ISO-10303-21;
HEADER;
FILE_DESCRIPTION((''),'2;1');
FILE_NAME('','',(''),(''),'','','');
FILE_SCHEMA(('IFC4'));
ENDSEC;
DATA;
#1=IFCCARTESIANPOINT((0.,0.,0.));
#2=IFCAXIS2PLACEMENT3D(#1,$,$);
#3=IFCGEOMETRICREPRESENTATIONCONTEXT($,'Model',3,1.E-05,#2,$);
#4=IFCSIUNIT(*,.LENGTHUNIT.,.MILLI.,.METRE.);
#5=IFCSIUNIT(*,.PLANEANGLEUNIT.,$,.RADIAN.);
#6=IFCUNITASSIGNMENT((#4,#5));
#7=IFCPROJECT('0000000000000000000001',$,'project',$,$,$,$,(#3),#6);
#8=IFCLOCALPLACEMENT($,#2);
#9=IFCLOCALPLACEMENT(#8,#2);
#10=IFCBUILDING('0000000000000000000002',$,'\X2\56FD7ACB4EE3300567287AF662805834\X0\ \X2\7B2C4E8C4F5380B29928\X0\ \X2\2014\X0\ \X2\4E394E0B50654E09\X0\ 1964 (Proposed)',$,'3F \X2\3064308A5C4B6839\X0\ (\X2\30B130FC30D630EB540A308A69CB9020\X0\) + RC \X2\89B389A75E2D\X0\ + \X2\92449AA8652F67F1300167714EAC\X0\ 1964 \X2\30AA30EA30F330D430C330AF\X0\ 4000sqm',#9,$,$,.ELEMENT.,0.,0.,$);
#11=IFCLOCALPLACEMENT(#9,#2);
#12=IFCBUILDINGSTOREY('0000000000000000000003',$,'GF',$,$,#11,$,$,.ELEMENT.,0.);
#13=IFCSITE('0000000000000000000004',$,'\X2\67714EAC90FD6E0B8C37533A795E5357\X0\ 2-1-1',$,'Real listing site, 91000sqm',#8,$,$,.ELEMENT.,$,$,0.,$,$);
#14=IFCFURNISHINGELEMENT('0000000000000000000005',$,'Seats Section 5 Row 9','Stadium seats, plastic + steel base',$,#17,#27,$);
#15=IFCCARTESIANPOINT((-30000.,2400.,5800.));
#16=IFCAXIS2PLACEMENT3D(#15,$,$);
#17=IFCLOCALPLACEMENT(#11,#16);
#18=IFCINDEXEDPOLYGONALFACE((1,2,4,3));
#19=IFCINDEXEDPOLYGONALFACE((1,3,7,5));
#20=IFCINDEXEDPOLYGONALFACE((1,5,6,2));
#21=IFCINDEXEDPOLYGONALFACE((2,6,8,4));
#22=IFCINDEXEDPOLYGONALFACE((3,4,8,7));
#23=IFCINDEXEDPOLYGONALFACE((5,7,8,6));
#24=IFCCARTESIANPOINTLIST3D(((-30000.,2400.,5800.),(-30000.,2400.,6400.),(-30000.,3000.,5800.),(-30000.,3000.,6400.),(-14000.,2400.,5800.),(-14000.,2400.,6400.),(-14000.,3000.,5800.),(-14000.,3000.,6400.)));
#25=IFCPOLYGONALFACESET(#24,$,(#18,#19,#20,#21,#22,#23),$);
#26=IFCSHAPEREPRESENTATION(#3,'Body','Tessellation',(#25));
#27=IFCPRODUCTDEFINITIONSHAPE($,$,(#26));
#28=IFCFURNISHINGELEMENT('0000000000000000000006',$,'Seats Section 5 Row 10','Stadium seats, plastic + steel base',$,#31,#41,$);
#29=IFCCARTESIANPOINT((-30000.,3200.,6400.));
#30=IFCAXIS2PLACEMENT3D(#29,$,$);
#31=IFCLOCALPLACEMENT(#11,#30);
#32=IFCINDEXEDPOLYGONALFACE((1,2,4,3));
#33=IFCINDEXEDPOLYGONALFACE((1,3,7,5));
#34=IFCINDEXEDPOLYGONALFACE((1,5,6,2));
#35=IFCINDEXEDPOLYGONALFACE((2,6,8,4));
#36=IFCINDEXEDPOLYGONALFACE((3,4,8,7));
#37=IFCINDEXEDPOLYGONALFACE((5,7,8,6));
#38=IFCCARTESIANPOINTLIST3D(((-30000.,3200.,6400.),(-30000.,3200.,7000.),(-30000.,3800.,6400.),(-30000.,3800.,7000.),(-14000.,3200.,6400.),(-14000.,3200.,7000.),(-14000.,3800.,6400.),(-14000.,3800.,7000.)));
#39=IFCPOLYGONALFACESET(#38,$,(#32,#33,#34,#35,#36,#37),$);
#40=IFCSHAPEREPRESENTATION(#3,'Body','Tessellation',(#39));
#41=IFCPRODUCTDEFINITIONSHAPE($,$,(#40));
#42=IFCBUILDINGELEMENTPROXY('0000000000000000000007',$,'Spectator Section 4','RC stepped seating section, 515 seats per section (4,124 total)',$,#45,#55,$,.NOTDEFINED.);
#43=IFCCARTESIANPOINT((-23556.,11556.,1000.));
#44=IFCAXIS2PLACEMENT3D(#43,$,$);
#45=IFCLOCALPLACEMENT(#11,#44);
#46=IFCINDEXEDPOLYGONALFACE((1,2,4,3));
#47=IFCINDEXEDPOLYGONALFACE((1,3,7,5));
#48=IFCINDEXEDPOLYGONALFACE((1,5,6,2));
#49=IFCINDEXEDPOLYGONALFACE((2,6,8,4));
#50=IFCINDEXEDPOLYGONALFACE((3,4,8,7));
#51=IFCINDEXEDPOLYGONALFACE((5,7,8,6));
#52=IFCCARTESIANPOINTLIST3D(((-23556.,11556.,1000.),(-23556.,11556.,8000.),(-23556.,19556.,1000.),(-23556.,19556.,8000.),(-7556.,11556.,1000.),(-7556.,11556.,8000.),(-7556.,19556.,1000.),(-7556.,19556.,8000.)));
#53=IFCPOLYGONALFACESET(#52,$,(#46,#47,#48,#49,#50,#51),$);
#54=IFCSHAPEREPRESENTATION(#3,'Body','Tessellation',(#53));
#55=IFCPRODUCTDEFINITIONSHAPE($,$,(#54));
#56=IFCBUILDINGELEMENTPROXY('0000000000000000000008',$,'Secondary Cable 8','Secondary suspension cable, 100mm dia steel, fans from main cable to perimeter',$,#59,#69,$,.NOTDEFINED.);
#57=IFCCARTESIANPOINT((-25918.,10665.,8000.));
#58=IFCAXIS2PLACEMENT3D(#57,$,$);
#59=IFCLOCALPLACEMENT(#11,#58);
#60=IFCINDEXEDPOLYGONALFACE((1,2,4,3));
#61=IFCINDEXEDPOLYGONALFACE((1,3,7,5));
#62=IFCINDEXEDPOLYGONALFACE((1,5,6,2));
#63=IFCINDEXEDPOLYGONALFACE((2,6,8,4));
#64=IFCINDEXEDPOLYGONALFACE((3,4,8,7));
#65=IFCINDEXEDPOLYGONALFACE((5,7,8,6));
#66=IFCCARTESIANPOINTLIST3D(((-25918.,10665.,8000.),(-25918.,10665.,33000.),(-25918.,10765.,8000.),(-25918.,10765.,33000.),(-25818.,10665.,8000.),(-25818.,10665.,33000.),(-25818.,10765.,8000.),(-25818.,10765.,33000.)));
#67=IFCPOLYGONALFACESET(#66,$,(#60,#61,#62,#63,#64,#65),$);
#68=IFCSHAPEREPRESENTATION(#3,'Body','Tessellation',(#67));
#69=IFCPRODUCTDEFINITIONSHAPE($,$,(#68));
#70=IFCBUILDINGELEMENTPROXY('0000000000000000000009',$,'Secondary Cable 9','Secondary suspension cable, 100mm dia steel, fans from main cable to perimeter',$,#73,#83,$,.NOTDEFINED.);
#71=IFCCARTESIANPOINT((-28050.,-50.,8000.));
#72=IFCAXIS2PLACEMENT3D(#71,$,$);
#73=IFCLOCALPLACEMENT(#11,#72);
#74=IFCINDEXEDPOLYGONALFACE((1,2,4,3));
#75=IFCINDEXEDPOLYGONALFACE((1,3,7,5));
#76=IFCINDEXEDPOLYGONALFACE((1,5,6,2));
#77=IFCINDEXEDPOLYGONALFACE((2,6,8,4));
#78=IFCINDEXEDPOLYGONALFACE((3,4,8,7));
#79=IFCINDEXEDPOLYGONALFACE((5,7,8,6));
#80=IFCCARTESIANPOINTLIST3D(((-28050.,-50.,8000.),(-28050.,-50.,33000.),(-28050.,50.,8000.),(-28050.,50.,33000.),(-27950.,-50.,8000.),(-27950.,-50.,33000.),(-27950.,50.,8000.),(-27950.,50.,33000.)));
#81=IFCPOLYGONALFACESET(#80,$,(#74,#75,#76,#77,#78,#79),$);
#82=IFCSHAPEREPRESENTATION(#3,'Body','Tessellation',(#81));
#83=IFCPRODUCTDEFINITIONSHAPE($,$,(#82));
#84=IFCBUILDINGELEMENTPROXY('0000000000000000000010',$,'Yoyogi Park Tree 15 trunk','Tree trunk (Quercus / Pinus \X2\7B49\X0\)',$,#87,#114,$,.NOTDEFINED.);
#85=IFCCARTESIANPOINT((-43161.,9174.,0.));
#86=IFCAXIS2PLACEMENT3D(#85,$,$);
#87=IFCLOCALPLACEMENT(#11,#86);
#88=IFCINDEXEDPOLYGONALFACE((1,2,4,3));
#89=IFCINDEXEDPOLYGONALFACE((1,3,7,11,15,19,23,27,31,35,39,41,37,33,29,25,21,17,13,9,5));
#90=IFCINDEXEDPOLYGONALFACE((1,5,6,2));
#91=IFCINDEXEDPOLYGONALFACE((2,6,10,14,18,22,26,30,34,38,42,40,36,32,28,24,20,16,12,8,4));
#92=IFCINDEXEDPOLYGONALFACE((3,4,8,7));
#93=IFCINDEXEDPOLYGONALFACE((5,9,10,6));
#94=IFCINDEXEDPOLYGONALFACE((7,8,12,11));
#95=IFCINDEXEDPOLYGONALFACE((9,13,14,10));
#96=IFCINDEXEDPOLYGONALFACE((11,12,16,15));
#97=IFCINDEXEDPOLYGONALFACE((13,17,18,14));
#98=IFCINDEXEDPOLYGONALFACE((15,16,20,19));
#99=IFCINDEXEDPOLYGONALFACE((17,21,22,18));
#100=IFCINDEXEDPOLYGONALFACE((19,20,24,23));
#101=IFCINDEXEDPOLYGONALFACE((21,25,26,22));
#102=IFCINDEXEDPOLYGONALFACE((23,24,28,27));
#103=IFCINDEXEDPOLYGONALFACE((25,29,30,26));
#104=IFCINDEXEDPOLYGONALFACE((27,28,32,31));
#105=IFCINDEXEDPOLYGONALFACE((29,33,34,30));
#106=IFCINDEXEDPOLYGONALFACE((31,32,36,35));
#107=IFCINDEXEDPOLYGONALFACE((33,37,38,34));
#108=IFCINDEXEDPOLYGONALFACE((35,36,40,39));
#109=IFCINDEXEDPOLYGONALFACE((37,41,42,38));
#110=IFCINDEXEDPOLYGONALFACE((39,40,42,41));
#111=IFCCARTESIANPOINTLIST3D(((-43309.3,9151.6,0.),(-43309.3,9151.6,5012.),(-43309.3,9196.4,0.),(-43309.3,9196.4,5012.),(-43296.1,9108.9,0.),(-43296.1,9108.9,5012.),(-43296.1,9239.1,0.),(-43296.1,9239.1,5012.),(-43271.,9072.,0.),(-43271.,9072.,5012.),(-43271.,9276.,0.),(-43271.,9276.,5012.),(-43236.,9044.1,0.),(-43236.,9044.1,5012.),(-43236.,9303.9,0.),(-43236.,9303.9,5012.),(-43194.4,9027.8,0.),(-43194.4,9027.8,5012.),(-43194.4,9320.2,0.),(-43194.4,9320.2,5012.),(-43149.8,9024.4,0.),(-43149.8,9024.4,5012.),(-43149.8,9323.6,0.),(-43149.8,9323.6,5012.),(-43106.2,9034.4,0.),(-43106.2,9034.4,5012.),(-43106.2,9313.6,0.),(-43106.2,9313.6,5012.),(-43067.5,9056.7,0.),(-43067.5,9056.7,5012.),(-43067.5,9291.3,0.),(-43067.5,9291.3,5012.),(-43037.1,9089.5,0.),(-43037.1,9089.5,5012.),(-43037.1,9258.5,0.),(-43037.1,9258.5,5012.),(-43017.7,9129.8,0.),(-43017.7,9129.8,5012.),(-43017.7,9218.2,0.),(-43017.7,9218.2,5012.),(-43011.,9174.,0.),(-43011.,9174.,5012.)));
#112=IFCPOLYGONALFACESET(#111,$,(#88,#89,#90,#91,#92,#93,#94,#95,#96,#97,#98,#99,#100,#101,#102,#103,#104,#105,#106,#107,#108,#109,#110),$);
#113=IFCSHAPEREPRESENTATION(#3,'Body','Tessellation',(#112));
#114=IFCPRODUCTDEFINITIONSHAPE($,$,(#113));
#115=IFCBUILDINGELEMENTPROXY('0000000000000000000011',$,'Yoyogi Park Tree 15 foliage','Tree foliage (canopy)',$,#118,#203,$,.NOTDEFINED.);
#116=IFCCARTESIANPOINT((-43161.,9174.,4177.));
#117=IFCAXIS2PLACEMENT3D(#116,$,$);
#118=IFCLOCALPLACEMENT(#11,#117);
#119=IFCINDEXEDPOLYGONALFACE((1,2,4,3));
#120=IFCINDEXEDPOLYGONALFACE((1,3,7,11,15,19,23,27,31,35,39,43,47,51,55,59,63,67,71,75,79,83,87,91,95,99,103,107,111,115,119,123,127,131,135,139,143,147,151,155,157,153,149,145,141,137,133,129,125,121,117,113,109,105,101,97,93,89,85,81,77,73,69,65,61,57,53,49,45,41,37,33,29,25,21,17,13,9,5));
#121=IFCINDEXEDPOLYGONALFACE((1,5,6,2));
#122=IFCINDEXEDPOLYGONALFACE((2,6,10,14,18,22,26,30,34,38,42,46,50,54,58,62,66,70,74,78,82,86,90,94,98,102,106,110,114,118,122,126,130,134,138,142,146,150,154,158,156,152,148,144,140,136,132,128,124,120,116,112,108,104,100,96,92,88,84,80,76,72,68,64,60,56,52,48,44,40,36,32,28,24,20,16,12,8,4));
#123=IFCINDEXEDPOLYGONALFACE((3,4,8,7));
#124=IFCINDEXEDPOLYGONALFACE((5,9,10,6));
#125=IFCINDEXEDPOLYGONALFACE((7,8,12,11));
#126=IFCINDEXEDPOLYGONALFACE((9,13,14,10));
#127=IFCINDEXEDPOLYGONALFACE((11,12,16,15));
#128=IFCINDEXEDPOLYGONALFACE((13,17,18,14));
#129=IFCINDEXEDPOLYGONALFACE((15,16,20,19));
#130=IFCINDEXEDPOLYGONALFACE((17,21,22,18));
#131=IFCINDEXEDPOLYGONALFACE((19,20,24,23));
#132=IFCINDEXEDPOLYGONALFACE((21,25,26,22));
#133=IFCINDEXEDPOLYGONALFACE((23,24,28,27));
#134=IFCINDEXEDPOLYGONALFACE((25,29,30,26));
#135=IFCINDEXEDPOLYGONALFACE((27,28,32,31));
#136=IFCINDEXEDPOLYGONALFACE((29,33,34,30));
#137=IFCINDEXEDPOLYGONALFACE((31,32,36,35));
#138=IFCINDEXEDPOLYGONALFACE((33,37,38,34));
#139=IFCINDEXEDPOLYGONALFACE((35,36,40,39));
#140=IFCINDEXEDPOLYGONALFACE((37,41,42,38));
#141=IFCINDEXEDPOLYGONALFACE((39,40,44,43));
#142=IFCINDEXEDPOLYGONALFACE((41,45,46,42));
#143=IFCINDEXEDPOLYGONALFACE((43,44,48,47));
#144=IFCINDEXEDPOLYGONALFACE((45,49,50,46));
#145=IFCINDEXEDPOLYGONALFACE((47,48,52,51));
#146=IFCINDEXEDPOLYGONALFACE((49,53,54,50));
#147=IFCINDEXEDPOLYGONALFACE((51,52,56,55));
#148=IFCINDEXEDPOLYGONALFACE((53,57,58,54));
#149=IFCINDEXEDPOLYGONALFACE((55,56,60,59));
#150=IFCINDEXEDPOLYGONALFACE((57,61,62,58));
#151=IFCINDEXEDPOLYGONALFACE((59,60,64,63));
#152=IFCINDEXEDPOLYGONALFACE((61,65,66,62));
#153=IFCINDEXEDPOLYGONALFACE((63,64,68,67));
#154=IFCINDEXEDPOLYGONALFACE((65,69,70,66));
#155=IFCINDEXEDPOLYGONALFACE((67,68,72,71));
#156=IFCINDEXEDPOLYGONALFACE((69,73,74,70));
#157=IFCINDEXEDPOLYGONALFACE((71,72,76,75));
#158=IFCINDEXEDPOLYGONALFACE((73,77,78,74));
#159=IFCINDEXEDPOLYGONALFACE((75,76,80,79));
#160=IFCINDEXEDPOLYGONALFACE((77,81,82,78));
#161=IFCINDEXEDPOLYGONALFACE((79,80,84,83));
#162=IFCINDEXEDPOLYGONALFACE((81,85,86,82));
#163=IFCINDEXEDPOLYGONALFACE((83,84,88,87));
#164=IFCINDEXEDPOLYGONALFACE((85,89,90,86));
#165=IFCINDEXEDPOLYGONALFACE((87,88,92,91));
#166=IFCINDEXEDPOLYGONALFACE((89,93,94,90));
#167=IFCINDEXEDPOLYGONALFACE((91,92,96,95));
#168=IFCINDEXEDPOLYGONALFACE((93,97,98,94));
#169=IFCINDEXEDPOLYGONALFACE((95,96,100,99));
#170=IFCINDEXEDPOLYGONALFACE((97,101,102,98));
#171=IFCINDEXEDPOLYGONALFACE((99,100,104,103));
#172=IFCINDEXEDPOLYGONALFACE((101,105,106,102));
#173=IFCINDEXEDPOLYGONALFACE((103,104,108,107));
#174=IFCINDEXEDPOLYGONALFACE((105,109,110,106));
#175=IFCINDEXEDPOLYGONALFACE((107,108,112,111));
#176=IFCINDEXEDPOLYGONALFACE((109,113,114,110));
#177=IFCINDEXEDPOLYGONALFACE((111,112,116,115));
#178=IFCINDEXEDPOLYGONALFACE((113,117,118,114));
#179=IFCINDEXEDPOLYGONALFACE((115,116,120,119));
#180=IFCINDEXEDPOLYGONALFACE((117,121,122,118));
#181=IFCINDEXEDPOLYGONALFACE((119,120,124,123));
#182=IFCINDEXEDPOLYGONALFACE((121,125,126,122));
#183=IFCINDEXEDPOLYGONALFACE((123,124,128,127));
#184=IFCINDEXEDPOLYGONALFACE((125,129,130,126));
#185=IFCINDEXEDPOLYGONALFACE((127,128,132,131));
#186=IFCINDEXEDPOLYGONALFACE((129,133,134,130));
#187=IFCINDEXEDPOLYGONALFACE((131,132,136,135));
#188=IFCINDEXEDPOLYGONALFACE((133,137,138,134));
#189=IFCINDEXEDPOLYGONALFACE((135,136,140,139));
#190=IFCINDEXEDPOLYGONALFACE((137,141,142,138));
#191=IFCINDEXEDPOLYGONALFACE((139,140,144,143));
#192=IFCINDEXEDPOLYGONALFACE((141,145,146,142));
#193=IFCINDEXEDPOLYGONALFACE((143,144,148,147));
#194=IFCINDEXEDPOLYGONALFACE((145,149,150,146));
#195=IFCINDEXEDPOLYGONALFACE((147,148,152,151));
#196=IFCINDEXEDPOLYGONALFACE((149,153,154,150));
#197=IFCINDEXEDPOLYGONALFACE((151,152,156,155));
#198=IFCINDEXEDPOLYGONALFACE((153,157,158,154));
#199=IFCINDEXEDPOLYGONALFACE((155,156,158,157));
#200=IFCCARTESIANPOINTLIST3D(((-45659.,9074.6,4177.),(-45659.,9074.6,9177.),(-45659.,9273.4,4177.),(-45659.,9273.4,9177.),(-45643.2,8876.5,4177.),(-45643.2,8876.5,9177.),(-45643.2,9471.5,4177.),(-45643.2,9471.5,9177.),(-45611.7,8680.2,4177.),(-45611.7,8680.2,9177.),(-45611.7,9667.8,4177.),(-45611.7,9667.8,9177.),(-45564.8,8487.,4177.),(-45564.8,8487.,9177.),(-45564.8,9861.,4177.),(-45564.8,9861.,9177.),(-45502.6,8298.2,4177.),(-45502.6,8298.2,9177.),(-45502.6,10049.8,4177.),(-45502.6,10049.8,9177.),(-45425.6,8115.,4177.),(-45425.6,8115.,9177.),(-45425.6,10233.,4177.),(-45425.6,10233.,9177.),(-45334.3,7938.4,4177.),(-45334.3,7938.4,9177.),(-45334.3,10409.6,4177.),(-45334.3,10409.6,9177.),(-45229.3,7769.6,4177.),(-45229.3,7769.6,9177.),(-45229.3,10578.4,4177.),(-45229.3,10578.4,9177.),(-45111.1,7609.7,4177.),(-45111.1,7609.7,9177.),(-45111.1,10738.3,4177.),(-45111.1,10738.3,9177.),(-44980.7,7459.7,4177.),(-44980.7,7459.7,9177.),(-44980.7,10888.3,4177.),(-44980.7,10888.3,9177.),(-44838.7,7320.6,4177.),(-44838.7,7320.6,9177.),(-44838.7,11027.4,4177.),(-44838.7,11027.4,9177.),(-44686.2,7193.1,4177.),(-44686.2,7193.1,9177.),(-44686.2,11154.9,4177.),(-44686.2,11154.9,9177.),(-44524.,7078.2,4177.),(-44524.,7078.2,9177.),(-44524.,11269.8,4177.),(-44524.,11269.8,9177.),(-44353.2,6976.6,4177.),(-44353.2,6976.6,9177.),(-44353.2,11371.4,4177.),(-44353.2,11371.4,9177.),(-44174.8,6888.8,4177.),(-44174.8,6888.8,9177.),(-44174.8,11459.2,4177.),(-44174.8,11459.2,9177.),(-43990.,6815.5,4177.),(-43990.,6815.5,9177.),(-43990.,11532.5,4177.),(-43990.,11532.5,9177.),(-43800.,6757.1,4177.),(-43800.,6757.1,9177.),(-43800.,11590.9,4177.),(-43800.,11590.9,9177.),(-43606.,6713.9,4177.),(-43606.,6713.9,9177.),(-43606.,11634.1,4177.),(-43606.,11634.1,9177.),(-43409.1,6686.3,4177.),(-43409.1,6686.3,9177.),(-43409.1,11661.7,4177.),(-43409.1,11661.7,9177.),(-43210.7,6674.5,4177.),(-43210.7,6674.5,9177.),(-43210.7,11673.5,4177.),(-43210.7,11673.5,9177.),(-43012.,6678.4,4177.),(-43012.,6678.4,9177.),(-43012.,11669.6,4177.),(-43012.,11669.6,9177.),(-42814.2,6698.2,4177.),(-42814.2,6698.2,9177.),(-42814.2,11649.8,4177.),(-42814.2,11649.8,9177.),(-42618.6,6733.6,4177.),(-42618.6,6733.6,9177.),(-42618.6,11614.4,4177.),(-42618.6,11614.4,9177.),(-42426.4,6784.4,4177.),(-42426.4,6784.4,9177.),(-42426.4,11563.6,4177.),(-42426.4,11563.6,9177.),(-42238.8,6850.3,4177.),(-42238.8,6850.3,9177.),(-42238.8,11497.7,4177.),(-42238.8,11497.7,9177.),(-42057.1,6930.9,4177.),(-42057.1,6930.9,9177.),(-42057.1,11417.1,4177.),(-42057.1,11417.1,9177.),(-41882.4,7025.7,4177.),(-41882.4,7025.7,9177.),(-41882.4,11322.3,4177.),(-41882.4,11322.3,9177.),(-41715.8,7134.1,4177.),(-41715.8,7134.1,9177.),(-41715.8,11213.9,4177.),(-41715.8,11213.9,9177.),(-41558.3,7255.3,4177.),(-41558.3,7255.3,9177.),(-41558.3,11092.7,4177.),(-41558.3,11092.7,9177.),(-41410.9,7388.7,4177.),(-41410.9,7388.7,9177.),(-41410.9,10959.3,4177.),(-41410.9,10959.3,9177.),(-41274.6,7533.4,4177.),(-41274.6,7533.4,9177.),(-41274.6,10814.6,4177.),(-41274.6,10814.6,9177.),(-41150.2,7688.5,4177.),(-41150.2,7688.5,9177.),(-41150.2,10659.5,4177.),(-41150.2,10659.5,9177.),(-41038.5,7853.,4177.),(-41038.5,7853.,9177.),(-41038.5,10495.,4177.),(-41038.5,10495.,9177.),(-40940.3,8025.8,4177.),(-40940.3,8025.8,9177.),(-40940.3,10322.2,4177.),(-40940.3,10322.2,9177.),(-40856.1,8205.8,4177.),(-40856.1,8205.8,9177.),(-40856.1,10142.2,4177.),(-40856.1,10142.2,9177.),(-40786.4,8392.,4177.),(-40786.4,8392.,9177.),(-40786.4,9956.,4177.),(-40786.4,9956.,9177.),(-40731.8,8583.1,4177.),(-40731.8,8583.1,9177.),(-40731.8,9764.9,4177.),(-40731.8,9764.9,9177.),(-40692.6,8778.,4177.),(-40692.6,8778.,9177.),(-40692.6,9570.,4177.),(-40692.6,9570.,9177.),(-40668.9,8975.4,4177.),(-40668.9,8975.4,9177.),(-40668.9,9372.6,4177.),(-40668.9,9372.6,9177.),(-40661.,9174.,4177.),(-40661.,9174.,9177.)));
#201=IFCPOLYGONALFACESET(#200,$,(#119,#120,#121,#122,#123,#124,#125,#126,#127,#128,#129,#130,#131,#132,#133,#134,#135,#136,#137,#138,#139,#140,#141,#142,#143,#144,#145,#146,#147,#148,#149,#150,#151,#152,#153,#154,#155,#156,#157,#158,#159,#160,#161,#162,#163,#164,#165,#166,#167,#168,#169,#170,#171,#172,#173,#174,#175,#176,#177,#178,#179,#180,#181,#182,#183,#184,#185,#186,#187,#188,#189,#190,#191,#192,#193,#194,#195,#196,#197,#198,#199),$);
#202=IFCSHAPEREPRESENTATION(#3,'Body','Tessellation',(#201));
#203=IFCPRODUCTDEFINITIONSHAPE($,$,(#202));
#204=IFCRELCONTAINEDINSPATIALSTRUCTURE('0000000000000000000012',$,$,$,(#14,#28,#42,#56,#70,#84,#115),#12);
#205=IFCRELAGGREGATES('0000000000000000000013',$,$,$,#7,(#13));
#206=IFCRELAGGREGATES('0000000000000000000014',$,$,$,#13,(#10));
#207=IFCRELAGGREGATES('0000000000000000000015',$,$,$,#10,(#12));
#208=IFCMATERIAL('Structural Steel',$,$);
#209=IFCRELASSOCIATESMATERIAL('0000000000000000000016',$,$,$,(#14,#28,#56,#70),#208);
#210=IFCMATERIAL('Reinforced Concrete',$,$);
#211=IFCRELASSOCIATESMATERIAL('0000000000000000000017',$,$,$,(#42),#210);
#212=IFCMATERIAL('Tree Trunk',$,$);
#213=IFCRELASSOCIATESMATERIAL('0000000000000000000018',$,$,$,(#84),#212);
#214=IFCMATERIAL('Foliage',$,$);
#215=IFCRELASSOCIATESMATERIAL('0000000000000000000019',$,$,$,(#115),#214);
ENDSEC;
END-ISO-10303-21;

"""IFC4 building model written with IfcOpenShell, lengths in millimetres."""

from ifc_helpers import new_model, si_unit, frame, frame_2d, origin, origin_2d, place, context, project, spatial, rectangle, circle, extrude, material, element, save


model = new_model("IFC4")

# Units and contexts
model_context = context("Model", 3, precision=1e-05, world=origin())
ifc_project = project(units=[si_unit("LENGTHUNIT", "METRE", prefix="MILLI"), si_unit("PLANEANGLEUNIT", "RADIAN")], contexts=[model_context])

# Site, building, storey
site_placement = place(None, origin())
site = spatial("IfcSite", under=ifc_project, at=site_placement, Name="東京都渋谷区神南 2-1-1", ObjectType="Real listing site, 91000sqm", CompositionType="ELEMENT", RefElevation=0.0)
building_placement = place(site_placement, origin())
building = spatial("IfcBuilding", under=site, at=building_placement, Name="国立代々木競技場 第二体育館 — 丹下健三 1964 (Proposed)", ObjectType="3F つり屋根 (ケーブル吊り構造) + RC 観覧席 + 鉄骨支柱、東京 1964 オリンピック 4000sqm", CompositionType="ELEMENT", ElevationOfRefHeight=0.0, ElevationOfTerrain=0.0)
storey_placement = place(building_placement, origin())
storey = spatial("IfcBuildingStorey", under=building, at=storey_placement, Name="GF", CompositionType="ELEMENT", Elevation=0.0)

# Shared definitions
ifc_material_1 = material(Name="Structural Steel")

# Furnishing elements
furnishing_1_placement = place(storey_placement, frame((-30000.0, 2400.0, 5800.0)))
element("IfcFurnishingElement", 1, at=furnishing_1_placement, inside=storey, material=ifc_material_1, Name="Seats Section 5 Row 9", Description="Stadium seats, plastic + steel base", context=model_context, shape_type="SweptSolid", body=[
    extrude(rectangle(XDim=16000.0, YDim=600.0, at=frame_2d((8000.0, 300.0))), frame((-30000.0, 2400.0, 5800.0)), (0.0, 0.0, 1.0), 600.0),
])
furnishing_2_placement = place(storey_placement, frame((-30000.0, 3200.0, 6400.0)))
element("IfcFurnishingElement", 2, at=furnishing_2_placement, inside=storey, material=ifc_material_1, Name="Seats Section 5 Row 10", Description="Stadium seats, plastic + steel base", context=model_context, shape_type="SweptSolid", body=[
    extrude(rectangle(XDim=16000.0, YDim=600.0, at=frame_2d((8000.0, 300.0))), frame((-30000.0, 3200.0, 6400.0)), (0.0, 0.0, 1.0), 600.0),
])

# Building element proxies
ifc_material_2 = material(Name="Reinforced Concrete")
proxy_1_placement = place(storey_placement, frame((-23556.0, 11556.0, 1000.0)))
element("IfcBuildingElementProxy", 3, at=proxy_1_placement, inside=storey, material=ifc_material_2, Name="Spectator Section 4", Description="RC stepped seating section, 515 seats per section (4,124 total)", PredefinedType="NOTDEFINED", context=model_context, shape_type="SweptSolid", body=[
    extrude(rectangle(XDim=16000.0, YDim=8000.0, at=frame_2d((8000.0, 4000.0))), frame((-23556.0, 11556.0, 1000.0)), (0.0, 0.0, 1.0), 7000.0),
])
proxy_2_placement = place(storey_placement, frame((-25918.0, 10665.0, 8000.0)))
element("IfcBuildingElementProxy", 4, at=proxy_2_placement, inside=storey, material=ifc_material_1, Name="Secondary Cable 8", Description="Secondary suspension cable, 100mm dia steel, fans from main cable to perimeter", PredefinedType="NOTDEFINED", context=model_context, shape_type="SweptSolid", body=[
    extrude(rectangle(XDim=100.0, YDim=100.0, at=frame_2d((50.0, 50.0))), frame((-25918.0, 10665.0, 8000.0)), (0.0, 0.0, 1.0), 25000.0),
])
proxy_3_placement = place(storey_placement, frame((-28050.0, -50.0, 8000.0)))
element("IfcBuildingElementProxy", 5, at=proxy_3_placement, inside=storey, material=ifc_material_1, Name="Secondary Cable 9", Description="Secondary suspension cable, 100mm dia steel, fans from main cable to perimeter", PredefinedType="NOTDEFINED", context=model_context, shape_type="SweptSolid", body=[
    extrude(rectangle(XDim=100.0, YDim=100.0, at=frame_2d((50.0, 50.0))), frame((-28050.0, -50.0, 8000.0)), (0.0, 0.0, 1.0), 25000.0),
])
ifc_material_3 = material(Name="Tree Trunk")
proxy_4_placement = place(storey_placement, frame((-43161.0, 9174.0, 0.0)))
element("IfcBuildingElementProxy", 6, at=proxy_4_placement, inside=storey, material=ifc_material_3, Name="Yoyogi Park Tree 15 trunk", Description="Tree trunk (Quercus / Pinus 等)", PredefinedType="NOTDEFINED", context=model_context, shape_type="SweptSolid", body=[
    extrude(circle(Radius=150.0, at=origin_2d()), frame((-43161.0, 9174.0, 0.0)), (0.0, 0.0, 1.0), 5012.0),
])
ifc_material_4 = material(Name="Foliage")
proxy_5_placement = place(storey_placement, frame((-43161.0, 9174.0, 4177.0)))
element("IfcBuildingElementProxy", 7, at=proxy_5_placement, inside=storey, material=ifc_material_4, Name="Yoyogi Park Tree 15 foliage", Description="Tree foliage (canopy)", PredefinedType="NOTDEFINED", context=model_context, shape_type="SweptSolid", body=[
    extrude(circle(Radius=2500.0, at=origin_2d()), frame((-43161.0, 9174.0, 4177.0)), (0.0, 0.0, 1.0), 5000.0),
])

save(model, "model.ifc")
